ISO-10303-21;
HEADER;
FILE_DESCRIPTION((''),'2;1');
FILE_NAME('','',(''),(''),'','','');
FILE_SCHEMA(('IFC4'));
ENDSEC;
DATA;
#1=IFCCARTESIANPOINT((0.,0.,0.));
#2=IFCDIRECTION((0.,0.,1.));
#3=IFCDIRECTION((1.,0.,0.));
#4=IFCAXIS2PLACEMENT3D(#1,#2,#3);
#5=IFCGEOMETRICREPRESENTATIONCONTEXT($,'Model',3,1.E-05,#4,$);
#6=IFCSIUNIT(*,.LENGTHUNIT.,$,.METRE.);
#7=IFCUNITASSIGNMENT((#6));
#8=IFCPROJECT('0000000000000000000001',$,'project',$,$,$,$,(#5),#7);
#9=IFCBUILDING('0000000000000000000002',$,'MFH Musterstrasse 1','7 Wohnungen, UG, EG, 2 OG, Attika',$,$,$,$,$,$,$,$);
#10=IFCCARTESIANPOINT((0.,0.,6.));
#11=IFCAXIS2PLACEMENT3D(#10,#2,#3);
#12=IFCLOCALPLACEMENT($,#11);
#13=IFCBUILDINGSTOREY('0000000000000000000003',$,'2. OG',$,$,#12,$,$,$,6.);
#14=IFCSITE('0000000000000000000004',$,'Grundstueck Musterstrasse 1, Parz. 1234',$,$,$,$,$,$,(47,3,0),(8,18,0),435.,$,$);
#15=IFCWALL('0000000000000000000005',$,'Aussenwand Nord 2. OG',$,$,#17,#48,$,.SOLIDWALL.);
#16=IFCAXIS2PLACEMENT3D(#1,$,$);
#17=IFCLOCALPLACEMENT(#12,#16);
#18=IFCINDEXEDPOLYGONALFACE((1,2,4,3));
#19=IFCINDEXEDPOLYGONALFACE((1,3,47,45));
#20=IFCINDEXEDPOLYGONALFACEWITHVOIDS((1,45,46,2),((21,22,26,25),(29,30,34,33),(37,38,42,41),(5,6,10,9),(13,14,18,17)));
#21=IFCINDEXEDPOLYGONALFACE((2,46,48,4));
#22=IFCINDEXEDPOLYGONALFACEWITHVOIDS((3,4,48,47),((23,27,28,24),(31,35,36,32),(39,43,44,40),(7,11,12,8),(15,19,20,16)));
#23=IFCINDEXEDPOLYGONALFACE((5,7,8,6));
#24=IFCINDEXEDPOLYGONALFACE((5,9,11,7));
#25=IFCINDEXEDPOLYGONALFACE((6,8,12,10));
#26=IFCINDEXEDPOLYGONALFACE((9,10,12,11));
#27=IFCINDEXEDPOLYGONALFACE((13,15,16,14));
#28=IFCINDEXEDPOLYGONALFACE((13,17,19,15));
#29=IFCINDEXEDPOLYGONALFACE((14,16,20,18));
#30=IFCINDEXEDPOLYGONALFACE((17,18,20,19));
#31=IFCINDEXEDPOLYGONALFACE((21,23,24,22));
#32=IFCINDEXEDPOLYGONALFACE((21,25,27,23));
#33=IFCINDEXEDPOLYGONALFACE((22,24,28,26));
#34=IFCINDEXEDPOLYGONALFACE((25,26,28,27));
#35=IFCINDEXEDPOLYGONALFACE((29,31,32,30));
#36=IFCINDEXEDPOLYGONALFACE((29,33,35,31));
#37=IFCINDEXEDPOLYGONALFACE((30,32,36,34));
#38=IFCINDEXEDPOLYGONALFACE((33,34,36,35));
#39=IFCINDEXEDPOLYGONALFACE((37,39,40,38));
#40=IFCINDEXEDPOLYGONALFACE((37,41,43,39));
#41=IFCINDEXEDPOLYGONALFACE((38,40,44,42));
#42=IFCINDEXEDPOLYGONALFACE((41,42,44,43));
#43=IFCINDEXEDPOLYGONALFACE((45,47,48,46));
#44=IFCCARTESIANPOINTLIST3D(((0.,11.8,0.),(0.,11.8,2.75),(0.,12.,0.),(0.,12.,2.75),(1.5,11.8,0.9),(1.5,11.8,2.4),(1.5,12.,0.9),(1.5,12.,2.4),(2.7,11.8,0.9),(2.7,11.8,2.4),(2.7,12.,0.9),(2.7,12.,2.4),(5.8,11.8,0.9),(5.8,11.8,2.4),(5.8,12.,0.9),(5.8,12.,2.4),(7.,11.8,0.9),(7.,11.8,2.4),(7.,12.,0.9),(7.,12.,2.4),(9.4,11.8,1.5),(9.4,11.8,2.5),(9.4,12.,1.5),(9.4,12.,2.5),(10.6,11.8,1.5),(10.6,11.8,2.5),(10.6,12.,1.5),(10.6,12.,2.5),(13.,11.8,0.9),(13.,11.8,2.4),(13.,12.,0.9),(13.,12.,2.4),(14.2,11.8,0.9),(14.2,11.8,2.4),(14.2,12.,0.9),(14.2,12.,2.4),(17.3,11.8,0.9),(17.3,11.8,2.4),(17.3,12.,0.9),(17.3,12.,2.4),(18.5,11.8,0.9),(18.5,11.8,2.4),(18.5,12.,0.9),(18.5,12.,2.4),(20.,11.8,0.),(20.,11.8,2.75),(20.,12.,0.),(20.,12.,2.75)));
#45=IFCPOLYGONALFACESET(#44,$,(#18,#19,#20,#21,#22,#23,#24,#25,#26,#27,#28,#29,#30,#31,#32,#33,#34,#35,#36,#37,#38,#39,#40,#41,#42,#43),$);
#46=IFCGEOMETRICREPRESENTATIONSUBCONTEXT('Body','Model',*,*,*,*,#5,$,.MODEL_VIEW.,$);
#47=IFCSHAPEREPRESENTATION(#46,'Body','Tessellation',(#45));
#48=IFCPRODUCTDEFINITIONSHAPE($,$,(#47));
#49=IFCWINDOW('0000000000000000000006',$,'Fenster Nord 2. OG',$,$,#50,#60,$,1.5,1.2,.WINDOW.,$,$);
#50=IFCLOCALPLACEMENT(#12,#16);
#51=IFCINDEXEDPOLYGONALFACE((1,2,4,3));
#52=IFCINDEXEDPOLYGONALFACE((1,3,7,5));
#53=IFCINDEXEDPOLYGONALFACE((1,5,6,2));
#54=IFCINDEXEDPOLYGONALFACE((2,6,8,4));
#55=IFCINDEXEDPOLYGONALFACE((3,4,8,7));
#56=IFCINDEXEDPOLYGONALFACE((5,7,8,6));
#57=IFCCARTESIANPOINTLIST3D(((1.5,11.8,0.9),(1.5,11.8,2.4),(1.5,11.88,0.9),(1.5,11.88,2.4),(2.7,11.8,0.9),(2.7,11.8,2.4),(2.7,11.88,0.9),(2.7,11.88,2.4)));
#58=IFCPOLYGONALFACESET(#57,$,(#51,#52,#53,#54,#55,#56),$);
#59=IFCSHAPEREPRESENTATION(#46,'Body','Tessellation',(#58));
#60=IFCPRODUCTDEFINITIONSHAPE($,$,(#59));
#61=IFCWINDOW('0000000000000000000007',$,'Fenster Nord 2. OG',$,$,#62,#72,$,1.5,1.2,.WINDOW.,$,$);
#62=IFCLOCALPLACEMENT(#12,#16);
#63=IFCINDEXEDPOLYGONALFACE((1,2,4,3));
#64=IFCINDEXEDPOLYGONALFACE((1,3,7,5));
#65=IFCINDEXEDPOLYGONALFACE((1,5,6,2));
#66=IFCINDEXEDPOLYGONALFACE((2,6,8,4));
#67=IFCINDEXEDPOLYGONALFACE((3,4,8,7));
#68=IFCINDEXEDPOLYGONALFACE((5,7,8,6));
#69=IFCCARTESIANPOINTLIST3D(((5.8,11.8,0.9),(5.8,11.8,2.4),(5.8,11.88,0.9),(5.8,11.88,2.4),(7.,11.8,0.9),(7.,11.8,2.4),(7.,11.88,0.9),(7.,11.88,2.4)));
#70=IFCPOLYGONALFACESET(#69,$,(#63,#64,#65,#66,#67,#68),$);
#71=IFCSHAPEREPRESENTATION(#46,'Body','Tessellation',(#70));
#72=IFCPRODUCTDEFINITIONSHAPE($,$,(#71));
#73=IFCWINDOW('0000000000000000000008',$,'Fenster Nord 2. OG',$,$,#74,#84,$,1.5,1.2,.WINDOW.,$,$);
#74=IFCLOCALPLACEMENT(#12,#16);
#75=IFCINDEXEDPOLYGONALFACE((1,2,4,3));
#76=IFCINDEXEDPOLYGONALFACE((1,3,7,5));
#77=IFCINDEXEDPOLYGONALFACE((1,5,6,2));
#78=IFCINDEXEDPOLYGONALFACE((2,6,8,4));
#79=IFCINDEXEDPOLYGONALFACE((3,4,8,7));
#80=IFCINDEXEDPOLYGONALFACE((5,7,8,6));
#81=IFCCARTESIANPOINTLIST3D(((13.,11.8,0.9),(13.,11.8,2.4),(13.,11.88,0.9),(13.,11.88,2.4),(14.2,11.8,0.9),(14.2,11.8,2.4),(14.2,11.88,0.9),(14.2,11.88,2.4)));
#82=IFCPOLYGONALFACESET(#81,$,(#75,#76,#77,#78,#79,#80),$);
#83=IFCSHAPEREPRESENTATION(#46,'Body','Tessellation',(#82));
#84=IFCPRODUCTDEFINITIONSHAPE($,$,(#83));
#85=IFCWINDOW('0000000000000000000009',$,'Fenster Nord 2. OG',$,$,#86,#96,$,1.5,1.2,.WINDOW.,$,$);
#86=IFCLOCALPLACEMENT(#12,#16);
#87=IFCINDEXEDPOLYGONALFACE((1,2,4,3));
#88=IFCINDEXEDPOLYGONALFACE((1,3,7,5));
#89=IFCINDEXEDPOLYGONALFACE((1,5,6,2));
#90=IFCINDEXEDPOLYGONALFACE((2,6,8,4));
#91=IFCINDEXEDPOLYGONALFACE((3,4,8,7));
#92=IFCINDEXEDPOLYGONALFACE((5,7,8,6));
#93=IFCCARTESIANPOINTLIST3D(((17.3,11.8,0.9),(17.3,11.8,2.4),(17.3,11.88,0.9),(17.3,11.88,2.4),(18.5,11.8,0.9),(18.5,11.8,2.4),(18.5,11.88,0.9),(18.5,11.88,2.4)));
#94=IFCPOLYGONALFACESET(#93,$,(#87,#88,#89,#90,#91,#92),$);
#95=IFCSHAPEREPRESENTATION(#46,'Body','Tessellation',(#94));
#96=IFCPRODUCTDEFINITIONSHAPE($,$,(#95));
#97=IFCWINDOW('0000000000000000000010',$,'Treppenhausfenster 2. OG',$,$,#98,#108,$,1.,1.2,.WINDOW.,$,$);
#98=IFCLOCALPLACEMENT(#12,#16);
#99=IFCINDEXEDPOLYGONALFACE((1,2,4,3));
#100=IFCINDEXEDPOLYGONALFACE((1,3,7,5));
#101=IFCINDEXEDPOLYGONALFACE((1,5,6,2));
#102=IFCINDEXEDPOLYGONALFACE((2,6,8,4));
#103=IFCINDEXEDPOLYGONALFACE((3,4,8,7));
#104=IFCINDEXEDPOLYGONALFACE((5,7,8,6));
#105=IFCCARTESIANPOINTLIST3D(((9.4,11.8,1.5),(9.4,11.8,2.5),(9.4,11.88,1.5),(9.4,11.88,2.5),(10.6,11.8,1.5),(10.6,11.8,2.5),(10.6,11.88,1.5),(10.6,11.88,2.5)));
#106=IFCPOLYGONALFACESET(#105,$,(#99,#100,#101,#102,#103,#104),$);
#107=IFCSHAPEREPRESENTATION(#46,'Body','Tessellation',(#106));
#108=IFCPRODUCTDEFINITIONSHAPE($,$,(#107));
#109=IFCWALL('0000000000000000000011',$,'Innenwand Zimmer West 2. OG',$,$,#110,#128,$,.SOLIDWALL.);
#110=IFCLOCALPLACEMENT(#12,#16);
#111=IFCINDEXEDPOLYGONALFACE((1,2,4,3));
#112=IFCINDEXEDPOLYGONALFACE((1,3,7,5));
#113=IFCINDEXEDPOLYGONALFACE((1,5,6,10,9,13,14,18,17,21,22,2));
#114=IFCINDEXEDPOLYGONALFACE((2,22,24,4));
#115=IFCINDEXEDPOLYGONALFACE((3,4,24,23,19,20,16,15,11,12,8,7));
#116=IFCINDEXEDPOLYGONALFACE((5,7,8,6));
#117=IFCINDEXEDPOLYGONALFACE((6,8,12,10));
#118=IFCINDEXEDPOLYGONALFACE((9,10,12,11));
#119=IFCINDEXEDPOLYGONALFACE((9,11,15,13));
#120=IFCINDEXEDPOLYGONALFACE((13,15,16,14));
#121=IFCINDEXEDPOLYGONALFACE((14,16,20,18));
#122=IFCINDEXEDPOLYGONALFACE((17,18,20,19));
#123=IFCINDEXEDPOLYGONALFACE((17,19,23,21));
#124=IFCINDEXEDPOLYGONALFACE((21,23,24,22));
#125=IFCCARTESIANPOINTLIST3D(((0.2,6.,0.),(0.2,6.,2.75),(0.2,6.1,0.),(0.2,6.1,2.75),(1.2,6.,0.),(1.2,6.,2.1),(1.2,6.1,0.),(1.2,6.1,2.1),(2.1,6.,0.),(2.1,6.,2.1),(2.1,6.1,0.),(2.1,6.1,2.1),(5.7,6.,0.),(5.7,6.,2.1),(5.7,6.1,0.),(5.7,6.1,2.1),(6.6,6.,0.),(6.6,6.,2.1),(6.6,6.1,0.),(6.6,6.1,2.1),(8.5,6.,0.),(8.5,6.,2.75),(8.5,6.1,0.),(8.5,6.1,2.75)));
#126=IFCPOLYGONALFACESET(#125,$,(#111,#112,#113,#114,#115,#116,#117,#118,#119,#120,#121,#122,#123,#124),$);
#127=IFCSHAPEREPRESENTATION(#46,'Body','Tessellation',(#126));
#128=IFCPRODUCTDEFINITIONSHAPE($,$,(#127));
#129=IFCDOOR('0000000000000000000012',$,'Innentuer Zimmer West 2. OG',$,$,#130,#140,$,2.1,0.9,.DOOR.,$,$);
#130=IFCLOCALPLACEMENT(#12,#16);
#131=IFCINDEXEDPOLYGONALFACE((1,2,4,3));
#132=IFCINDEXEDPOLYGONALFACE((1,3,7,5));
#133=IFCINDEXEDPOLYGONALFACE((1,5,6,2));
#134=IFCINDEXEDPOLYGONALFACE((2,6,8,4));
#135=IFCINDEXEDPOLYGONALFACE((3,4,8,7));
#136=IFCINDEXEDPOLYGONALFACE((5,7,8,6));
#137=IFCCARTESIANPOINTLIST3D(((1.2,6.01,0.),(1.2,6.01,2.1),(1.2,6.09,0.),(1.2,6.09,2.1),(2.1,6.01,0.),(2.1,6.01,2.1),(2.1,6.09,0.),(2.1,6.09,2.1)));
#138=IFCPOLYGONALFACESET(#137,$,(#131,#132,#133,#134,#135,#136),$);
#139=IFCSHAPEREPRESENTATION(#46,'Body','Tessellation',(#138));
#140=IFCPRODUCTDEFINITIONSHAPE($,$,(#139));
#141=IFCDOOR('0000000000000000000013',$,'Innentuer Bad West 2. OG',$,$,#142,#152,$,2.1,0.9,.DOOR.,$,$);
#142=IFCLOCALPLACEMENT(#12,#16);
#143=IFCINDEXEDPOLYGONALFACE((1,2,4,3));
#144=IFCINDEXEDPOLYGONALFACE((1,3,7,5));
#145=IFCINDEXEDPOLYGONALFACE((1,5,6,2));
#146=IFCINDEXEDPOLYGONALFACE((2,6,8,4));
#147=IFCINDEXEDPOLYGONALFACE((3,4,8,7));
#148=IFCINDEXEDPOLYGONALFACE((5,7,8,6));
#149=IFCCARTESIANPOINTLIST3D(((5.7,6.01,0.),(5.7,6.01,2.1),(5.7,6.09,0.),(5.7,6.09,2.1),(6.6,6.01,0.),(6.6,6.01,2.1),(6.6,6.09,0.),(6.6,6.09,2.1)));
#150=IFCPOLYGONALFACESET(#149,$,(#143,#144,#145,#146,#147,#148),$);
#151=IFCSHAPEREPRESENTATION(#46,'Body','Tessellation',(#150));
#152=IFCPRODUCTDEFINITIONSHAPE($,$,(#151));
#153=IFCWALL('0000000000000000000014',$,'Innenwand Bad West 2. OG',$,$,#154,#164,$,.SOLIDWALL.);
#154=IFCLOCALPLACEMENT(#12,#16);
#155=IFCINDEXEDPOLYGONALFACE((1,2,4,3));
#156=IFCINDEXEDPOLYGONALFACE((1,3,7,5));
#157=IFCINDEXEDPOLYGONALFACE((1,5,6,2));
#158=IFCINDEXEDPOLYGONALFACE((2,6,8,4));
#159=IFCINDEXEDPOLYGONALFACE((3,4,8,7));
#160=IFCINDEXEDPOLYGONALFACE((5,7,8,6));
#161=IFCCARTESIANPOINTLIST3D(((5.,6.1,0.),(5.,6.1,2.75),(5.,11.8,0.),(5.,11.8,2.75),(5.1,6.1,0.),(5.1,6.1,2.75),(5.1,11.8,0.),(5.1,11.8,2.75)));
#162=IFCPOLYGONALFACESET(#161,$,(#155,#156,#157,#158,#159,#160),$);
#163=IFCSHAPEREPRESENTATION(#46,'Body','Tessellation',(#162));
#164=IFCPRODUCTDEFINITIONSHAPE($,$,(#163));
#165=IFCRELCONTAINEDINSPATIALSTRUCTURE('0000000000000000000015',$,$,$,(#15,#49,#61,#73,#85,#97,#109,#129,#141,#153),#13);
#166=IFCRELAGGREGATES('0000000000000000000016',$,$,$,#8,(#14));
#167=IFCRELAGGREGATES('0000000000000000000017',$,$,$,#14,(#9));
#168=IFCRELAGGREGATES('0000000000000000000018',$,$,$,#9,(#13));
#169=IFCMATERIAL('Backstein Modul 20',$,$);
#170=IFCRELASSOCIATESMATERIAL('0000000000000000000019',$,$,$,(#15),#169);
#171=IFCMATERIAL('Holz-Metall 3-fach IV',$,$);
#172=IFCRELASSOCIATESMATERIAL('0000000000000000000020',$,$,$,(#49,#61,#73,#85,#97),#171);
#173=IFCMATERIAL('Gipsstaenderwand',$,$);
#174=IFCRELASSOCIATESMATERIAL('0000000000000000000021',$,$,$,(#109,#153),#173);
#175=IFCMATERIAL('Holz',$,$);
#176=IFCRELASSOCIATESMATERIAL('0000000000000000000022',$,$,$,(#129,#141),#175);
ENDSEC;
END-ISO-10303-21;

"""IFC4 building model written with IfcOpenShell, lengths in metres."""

from ifc_helpers import new_model, si_unit, frame, frame_2d, origin_with_axes, place, context, subcontext, project, spatial, rectangle, extrude, material, element, fill, save


model = new_model("IFC4")

# Units and contexts
model_context = context("Model", 3, precision=1e-05, world=origin_with_axes())
body_context = subcontext(model_context, "Body", "Model", "MODEL_VIEW")
ifc_project = project(units=[si_unit("LENGTHUNIT", "METRE")], contexts=[model_context])

# Site, building, storey
site = spatial("IfcSite", under=ifc_project, Name="Grundstueck Musterstrasse 1, Parz. 1234", RefLatitude=(47, 3, 0), RefLongitude=(8, 18, 0), RefElevation=435.0)
building = spatial("IfcBuilding", under=site, Name="MFH Musterstrasse 1", Description="7 Wohnungen, UG, EG, 2 OG, Attika")
storey_placement = place(None, frame((0.0, 0.0, 6.0), z_axis=(0.0, 0.0, 1.0), x_axis=(1.0, 0.0, 0.0)))
storey = spatial("IfcBuildingStorey", under=building, at=storey_placement, Name="2. OG", Elevation=6.0)

# Wall, openings, windows
ifc_material_1 = material(Name="Backstein Modul 20")
wall_1_placement = place(storey_placement, frame((0.0, 11.8, 0.0), z_axis=(0.0, 0.0, 1.0), x_axis=(1.0, 0.0, 0.0)))
wall_1 = element("IfcWall", 1, at=wall_1_placement, inside=storey, material=ifc_material_1, Name="Aussenwand Nord 2. OG", PredefinedType="SOLIDWALL", context=body_context, shape_type="SweptSolid", body=[
    extrude(rectangle(XDim=20.0, YDim=0.2, at=frame_2d((10.0, 0.1))), origin_with_axes(), (0.0, 0.0, 1.0), 2.75),
])
opening_1_placement = place(wall_1_placement, frame((1.5, -0.01, 0.9), z_axis=(0.0, 0.0, 1.0), x_axis=(1.0, 0.0, 0.0)))
opening_1 = element("IfcOpeningElement", 2, at=opening_1_placement, cuts=wall_1, context=body_context, shape_type="SweptSolid", body=[
    extrude(rectangle(XDim=1.2, YDim=0.42, at=frame_2d((0.6, 0.21))), origin_with_axes(), (0.0, 0.0, 1.0), 1.5),
])
opening_2_placement = place(wall_1_placement, frame((5.8, -0.01, 0.9), z_axis=(0.0, 0.0, 1.0), x_axis=(1.0, 0.0, 0.0)))
opening_2 = element("IfcOpeningElement", 3, at=opening_2_placement, cuts=wall_1, context=body_context, shape_type="SweptSolid", body=[
    extrude(rectangle(XDim=1.2, YDim=0.42, at=frame_2d((0.6, 0.21))), origin_with_axes(), (0.0, 0.0, 1.0), 1.5),
])
opening_3_placement = place(wall_1_placement, frame((13.0, -0.01, 0.9), z_axis=(0.0, 0.0, 1.0), x_axis=(1.0, 0.0, 0.0)))
opening_3 = element("IfcOpeningElement", 4, at=opening_3_placement, cuts=wall_1, context=body_context, shape_type="SweptSolid", body=[
    extrude(rectangle(XDim=1.2, YDim=0.42, at=frame_2d((0.6, 0.21))), origin_with_axes(), (0.0, 0.0, 1.0), 1.5),
])
opening_4_placement = place(wall_1_placement, frame((17.3, -0.01, 0.9), z_axis=(0.0, 0.0, 1.0), x_axis=(1.0, 0.0, 0.0)))
opening_4 = element("IfcOpeningElement", 5, at=opening_4_placement, cuts=wall_1, context=body_context, shape_type="SweptSolid", body=[
    extrude(rectangle(XDim=1.2, YDim=0.42, at=frame_2d((0.6, 0.21))), origin_with_axes(), (0.0, 0.0, 1.0), 1.5),
])
opening_5_placement = place(wall_1_placement, frame((9.4, -0.01, 1.5), z_axis=(0.0, 0.0, 1.0), x_axis=(1.0, 0.0, 0.0)))
opening_5 = element("IfcOpeningElement", 6, at=opening_5_placement, cuts=wall_1, context=body_context, shape_type="SweptSolid", body=[
    extrude(rectangle(XDim=1.2, YDim=0.42, at=frame_2d((0.6, 0.21))), origin_with_axes(), (0.0, 0.0, 1.0), 1.0),
])
ifc_material_2 = material(Name="Holz-Metall 3-fach IV")
window_1_placement = place(storey_placement, frame((1.5, 11.8, 0.9), z_axis=(0.0, 0.0, 1.0), x_axis=(1.0, 0.0, 0.0)))
window_1 = element("IfcWindow", 7, at=window_1_placement, inside=storey, material=ifc_material_2, Name="Fenster Nord 2. OG", OverallHeight=1.5, OverallWidth=1.2, PredefinedType="WINDOW", context=body_context, shape_type="SweptSolid", body=[
    extrude(rectangle(XDim=1.2, YDim=0.08, at=frame_2d((0.6, 0.04))), origin_with_axes(), (0.0, 0.0, 1.0), 1.5),
])
fill(opening_1, window_1)
window_2_placement = place(storey_placement, frame((5.8, 11.8, 0.9), z_axis=(0.0, 0.0, 1.0), x_axis=(1.0, 0.0, 0.0)))
window_2 = element("IfcWindow", 8, at=window_2_placement, inside=storey, material=ifc_material_2, Name="Fenster Nord 2. OG", OverallHeight=1.5, OverallWidth=1.2, PredefinedType="WINDOW", context=body_context, shape_type="SweptSolid", body=[
    extrude(rectangle(XDim=1.2, YDim=0.08, at=frame_2d((0.6, 0.04))), origin_with_axes(), (0.0, 0.0, 1.0), 1.5),
])
fill(opening_2, window_2)
window_3_placement = place(storey_placement, frame((13.0, 11.8, 0.9), z_axis=(0.0, 0.0, 1.0), x_axis=(1.0, 0.0, 0.0)))
window_3 = element("IfcWindow", 9, at=window_3_placement, inside=storey, material=ifc_material_2, Name="Fenster Nord 2. OG", OverallHeight=1.5, OverallWidth=1.2, PredefinedType="WINDOW", context=body_context, shape_type="SweptSolid", body=[
    extrude(rectangle(XDim=1.2, YDim=0.08, at=frame_2d((0.6, 0.04))), origin_with_axes(), (0.0, 0.0, 1.0), 1.5),
])
fill(opening_3, window_3)
window_4_placement = place(storey_placement, frame((17.3, 11.8, 0.9), z_axis=(0.0, 0.0, 1.0), x_axis=(1.0, 0.0, 0.0)))
window_4 = element("IfcWindow", 10, at=window_4_placement, inside=storey, material=ifc_material_2, Name="Fenster Nord 2. OG", OverallHeight=1.5, OverallWidth=1.2, PredefinedType="WINDOW", context=body_context, shape_type="SweptSolid", body=[
    extrude(rectangle(XDim=1.2, YDim=0.08, at=frame_2d((0.6, 0.04))), origin_with_axes(), (0.0, 0.0, 1.0), 1.5),
])
fill(opening_4, window_4)
window_5_placement = place(storey_placement, frame((9.4, 11.8, 1.5), z_axis=(0.0, 0.0, 1.0), x_axis=(1.0, 0.0, 0.0)))
window_5 = element("IfcWindow", 11, at=window_5_placement, inside=storey, material=ifc_material_2, Name="Treppenhausfenster 2. OG", OverallHeight=1.0, OverallWidth=1.2, PredefinedType="WINDOW", context=body_context, shape_type="SweptSolid", body=[
    extrude(rectangle(XDim=1.2, YDim=0.08, at=frame_2d((0.6, 0.04))), origin_with_axes(), (0.0, 0.0, 1.0), 1.0),
])
fill(opening_5, window_5)

# Wall, openings, doors
ifc_material_3 = material(Name="Gipsstaenderwand")
wall_2_placement = place(storey_placement, frame((0.2, 6.0, 0.0), z_axis=(0.0, 0.0, 1.0), x_axis=(1.0, 0.0, 0.0)))
wall_2 = element("IfcWall", 12, at=wall_2_placement, inside=storey, material=ifc_material_3, Name="Innenwand Zimmer West 2. OG", PredefinedType="SOLIDWALL", context=body_context, shape_type="SweptSolid", body=[
    extrude(rectangle(XDim=8.3, YDim=0.1, at=frame_2d((4.15, 0.05))), origin_with_axes(), (0.0, 0.0, 1.0), 2.75),
])
opening_6_placement = place(wall_2_placement, frame((1.0, -0.01, 0.0), z_axis=(0.0, 0.0, 1.0), x_axis=(1.0, 0.0, 0.0)))
opening_6 = element("IfcOpeningElement", 13, at=opening_6_placement, cuts=wall_2, context=body_context, shape_type="SweptSolid", body=[
    extrude(rectangle(XDim=0.9, YDim=0.12, at=frame_2d((0.45, 0.06))), origin_with_axes(), (0.0, 0.0, 1.0), 2.1),
])
opening_7_placement = place(wall_2_placement, frame((5.5, -0.01, 0.0), z_axis=(0.0, 0.0, 1.0), x_axis=(1.0, 0.0, 0.0)))
opening_7 = element("IfcOpeningElement", 14, at=opening_7_placement, cuts=wall_2, context=body_context, shape_type="SweptSolid", body=[
    extrude(rectangle(XDim=0.9, YDim=0.12, at=frame_2d((0.45, 0.06))), origin_with_axes(), (0.0, 0.0, 1.0), 2.1),
])
ifc_material_4 = material(Name="Holz")
door_1_placement = place(storey_placement, frame((1.2, 6.01, 0.0), z_axis=(0.0, 0.0, 1.0), x_axis=(1.0, 0.0, 0.0)))
door_1 = element("IfcDoor", 15, at=door_1_placement, inside=storey, material=ifc_material_4, Name="Innentuer Zimmer West 2. OG", OverallHeight=2.1, OverallWidth=0.9, PredefinedType="DOOR", context=body_context, shape_type="SweptSolid", body=[
    extrude(rectangle(XDim=0.9, YDim=0.08, at=frame_2d((0.45, 0.04))), origin_with_axes(), (0.0, 0.0, 1.0), 2.1),
])
fill(opening_6, door_1)
door_2_placement = place(storey_placement, frame((5.7, 6.01, 0.0), z_axis=(0.0, 0.0, 1.0), x_axis=(1.0, 0.0, 0.0)))
door_2 = element("IfcDoor", 16, at=door_2_placement, inside=storey, material=ifc_material_4, Name="Innentuer Bad West 2. OG", OverallHeight=2.1, OverallWidth=0.9, PredefinedType="DOOR", context=body_context, shape_type="SweptSolid", body=[
    extrude(rectangle(XDim=0.9, YDim=0.08, at=frame_2d((0.45, 0.04))), origin_with_axes(), (0.0, 0.0, 1.0), 2.1),
])
fill(opening_7, door_2)

# Wall
wall_3_placement = place(storey_placement, frame((5.0, 6.1, 0.0), z_axis=(0.0, 0.0, 1.0), x_axis=(1.0, 0.0, 0.0)))
element("IfcWall", 17, at=wall_3_placement, inside=storey, material=ifc_material_3, Name="Innenwand Bad West 2. OG", PredefinedType="SOLIDWALL", context=body_context, shape_type="SweptSolid", body=[
    extrude(rectangle(XDim=0.1, YDim=5.7, at=frame_2d((0.05, 2.85))), origin_with_axes(), (0.0, 0.0, 1.0), 2.75),
])

save(model, "model.ifc")
